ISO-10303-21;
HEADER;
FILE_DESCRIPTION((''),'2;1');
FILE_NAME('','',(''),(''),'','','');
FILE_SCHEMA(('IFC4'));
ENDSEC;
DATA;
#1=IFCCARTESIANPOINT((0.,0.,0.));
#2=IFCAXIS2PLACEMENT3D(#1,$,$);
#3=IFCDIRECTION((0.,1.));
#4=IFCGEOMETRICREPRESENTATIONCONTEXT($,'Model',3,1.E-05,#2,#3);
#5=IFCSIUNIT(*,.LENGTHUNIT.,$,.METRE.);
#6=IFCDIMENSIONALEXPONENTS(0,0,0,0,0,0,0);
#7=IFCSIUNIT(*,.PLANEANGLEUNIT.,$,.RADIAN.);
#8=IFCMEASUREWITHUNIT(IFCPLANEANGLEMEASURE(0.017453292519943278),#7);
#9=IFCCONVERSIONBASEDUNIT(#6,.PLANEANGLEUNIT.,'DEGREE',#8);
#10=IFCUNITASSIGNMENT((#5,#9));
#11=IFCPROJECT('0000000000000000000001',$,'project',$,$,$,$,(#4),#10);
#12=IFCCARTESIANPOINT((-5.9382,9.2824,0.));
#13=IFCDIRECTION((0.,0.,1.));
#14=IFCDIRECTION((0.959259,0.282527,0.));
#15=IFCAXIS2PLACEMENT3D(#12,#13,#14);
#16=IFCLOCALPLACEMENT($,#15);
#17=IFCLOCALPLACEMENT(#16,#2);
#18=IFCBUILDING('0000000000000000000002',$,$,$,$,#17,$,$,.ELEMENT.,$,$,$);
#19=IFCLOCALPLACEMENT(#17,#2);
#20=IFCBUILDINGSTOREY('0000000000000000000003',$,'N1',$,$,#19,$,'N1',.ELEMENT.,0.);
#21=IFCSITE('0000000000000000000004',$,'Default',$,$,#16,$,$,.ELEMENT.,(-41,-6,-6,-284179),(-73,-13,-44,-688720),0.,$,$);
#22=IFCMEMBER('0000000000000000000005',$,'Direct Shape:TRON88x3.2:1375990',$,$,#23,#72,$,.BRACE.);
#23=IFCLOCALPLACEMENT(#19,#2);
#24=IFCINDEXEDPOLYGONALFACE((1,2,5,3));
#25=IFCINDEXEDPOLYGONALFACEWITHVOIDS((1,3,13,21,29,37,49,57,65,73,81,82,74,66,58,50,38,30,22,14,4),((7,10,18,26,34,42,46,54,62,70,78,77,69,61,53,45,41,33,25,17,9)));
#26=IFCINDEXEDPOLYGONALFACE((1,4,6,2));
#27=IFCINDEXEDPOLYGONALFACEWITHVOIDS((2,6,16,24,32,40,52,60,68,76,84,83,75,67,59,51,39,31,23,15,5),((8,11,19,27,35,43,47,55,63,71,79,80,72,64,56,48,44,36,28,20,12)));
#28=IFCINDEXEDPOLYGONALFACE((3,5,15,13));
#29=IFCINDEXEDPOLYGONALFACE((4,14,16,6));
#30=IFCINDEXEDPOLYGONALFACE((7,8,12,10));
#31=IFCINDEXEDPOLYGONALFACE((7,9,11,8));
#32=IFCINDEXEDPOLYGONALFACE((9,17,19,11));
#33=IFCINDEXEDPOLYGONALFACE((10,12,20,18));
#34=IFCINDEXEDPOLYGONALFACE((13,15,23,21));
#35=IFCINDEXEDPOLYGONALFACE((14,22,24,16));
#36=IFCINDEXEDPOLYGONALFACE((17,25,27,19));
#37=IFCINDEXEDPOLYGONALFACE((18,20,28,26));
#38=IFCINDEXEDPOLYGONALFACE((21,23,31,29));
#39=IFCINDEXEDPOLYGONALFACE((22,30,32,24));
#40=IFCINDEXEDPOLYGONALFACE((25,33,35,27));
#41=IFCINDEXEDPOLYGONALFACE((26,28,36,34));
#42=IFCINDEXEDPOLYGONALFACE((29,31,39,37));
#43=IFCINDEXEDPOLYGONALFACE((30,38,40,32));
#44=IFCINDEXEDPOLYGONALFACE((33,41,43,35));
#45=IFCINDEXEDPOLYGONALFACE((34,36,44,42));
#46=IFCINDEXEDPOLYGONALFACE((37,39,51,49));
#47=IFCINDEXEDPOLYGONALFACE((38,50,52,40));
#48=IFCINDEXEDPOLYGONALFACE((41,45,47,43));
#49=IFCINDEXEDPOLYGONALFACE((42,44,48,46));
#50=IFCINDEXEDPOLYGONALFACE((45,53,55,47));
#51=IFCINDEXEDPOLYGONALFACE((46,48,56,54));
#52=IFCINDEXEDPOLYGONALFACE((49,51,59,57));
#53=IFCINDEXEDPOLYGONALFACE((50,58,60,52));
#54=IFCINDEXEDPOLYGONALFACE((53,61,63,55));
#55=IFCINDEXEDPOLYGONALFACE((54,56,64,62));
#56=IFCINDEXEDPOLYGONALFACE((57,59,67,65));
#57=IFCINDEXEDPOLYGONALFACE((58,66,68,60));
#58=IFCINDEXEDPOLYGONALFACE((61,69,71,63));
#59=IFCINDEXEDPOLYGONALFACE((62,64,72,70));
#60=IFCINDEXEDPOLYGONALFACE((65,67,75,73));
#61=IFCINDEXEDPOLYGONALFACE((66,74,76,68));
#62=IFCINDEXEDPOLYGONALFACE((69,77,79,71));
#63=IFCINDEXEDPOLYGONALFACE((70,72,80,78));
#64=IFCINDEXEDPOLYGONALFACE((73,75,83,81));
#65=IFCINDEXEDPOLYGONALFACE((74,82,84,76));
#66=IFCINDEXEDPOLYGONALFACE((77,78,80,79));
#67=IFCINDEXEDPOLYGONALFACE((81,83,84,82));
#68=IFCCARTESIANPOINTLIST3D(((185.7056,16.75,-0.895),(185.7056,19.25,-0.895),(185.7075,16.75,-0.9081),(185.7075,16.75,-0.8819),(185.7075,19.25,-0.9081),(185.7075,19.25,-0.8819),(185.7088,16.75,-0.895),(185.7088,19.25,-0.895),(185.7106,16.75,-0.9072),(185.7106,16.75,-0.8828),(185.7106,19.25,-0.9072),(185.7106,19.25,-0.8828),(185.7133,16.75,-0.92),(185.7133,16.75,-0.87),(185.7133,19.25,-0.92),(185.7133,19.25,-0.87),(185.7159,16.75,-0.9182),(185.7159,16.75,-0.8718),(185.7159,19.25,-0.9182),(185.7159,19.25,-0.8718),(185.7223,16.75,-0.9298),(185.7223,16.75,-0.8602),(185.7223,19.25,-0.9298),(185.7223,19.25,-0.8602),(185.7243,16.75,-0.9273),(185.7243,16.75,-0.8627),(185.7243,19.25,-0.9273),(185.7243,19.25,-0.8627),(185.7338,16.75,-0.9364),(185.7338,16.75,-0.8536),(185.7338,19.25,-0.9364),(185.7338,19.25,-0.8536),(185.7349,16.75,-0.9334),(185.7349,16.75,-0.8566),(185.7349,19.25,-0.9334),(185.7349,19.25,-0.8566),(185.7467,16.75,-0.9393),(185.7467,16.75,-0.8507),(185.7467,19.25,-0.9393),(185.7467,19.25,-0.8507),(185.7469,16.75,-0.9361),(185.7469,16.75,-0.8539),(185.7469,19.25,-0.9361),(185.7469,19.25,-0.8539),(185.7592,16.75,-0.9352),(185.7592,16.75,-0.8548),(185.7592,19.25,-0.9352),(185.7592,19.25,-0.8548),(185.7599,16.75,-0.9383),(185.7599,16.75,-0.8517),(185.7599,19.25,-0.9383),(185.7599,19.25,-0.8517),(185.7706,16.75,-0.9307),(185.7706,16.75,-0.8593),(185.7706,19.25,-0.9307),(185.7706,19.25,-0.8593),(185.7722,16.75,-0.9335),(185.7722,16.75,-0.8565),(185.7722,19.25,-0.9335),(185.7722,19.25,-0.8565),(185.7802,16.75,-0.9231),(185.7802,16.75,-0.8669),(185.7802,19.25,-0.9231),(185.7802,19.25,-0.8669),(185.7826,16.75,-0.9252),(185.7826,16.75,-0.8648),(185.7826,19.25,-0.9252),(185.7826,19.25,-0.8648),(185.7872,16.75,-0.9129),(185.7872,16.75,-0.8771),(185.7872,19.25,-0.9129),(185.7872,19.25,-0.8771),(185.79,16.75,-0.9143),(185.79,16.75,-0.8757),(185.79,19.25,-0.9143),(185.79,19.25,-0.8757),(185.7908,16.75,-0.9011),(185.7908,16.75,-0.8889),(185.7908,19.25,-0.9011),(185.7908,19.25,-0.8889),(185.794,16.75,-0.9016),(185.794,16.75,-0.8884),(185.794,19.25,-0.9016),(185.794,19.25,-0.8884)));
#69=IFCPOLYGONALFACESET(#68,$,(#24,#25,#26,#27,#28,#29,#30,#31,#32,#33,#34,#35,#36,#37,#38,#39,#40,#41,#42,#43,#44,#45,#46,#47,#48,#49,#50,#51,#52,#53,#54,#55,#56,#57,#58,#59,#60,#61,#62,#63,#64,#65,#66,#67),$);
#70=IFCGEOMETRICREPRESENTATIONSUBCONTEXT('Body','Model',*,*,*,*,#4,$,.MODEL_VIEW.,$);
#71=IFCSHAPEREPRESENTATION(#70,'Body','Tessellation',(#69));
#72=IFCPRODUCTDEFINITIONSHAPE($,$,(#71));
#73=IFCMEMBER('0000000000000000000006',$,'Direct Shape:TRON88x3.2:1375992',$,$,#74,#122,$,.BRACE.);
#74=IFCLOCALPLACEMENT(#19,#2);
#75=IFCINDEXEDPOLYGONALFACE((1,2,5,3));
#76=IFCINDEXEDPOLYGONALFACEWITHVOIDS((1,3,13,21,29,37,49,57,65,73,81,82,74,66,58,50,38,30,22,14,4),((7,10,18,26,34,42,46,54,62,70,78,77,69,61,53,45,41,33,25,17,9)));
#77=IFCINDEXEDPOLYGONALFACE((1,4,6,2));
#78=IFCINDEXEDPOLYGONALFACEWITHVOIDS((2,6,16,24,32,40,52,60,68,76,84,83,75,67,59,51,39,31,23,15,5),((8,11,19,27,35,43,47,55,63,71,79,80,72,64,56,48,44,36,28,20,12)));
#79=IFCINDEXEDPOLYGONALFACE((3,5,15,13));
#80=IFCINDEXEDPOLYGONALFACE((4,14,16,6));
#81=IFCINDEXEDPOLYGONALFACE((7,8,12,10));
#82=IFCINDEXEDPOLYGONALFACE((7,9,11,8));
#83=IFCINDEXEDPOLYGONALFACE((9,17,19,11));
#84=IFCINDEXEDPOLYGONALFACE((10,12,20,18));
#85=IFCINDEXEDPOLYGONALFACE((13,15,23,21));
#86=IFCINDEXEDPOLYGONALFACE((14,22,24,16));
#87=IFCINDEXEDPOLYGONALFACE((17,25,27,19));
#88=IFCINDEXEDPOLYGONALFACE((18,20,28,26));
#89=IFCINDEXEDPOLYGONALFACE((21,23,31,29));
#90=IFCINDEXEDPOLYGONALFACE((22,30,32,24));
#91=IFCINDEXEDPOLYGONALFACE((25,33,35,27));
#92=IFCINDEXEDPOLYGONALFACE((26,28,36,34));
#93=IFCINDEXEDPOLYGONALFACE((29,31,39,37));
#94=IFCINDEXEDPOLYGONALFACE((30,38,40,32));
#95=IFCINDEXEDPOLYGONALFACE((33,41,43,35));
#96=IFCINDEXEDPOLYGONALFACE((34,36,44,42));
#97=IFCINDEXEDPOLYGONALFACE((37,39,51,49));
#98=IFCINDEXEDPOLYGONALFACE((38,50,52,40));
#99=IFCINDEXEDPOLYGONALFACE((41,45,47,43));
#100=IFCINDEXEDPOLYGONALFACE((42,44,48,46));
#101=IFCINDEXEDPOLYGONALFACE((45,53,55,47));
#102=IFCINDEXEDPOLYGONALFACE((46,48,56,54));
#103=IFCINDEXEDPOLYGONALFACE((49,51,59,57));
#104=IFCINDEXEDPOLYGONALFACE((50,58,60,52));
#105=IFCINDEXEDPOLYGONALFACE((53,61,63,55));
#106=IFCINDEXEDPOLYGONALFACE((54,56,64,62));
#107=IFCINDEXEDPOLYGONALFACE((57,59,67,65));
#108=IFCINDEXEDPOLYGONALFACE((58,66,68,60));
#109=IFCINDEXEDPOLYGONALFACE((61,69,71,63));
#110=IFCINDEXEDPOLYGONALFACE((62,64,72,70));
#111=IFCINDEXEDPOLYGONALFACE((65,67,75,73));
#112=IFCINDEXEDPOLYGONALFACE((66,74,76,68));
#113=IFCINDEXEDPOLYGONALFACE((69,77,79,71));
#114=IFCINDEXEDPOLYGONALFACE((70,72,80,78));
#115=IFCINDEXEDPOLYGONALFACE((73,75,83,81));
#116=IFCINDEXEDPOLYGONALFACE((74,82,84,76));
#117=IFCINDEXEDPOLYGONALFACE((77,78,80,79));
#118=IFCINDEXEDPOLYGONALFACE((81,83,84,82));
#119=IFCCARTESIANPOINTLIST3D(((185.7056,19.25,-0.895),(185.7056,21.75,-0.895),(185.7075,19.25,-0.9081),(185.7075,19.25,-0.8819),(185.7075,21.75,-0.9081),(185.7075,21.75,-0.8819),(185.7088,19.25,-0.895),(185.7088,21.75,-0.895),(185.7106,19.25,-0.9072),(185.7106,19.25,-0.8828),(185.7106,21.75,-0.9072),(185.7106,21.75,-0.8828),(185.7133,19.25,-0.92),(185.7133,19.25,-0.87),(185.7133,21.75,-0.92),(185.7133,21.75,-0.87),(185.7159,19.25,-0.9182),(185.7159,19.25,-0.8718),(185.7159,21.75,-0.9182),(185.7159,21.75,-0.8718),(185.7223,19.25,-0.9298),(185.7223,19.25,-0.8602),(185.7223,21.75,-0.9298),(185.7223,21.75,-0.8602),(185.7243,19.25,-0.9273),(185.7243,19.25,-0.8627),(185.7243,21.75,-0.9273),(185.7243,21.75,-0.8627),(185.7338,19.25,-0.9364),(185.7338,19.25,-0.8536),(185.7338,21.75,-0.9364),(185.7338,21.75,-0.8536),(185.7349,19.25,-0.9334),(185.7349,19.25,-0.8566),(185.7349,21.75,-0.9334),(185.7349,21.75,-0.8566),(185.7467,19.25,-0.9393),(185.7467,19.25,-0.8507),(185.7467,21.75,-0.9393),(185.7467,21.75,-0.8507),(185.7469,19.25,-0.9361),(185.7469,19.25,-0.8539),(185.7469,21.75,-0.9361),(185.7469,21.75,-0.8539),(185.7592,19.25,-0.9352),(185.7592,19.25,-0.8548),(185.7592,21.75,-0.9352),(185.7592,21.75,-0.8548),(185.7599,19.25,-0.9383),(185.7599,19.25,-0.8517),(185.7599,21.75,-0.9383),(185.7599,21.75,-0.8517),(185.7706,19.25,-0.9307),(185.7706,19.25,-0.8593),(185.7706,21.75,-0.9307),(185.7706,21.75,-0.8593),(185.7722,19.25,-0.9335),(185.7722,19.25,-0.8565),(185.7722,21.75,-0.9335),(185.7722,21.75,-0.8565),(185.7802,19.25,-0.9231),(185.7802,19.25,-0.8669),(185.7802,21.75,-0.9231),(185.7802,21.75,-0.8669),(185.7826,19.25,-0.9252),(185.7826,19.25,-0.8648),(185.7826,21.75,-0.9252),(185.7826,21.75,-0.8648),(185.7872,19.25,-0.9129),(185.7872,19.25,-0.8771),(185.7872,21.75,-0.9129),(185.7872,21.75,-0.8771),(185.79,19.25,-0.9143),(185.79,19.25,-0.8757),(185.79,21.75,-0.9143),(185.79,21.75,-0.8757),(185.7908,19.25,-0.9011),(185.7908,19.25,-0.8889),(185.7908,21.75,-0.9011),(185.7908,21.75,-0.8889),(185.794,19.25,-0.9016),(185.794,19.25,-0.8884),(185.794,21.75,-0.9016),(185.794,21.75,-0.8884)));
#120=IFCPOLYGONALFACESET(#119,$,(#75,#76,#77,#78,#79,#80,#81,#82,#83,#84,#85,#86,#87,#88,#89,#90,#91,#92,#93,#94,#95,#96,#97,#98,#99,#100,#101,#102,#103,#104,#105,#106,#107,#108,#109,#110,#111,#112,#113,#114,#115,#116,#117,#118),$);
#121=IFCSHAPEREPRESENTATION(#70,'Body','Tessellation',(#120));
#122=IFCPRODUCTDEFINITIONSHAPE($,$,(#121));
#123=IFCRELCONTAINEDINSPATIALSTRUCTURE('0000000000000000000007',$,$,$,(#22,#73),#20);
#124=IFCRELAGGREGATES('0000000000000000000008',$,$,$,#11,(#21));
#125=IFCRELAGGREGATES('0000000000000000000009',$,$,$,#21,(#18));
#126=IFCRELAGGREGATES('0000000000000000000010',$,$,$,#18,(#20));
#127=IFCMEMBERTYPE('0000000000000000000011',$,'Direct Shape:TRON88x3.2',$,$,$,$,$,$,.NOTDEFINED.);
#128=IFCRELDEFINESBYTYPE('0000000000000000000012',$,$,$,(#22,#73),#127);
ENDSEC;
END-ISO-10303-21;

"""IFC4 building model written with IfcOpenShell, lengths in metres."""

from ifc_helpers import new_model, entity, si_unit, converted_unit, direction, frame, frame_2d, origin, place, context, subcontext, project, spatial, hollow_circle, extrude, type_object, element, save


model = new_model("IFC4")

# Units and contexts
model_context = context("Model", 3, precision=1e-05, world=origin(), true_north=direction((0.0, 1.0)))
body_context = subcontext(model_context, "Body", "Model", "MODEL_VIEW")
ifc_project = project(units=[si_unit("LENGTHUNIT", "METRE"), converted_unit("PLANEANGLEUNIT", "DEGREE", entity("IfcPlaneAngleMeasure", 0.017453292519943278), si_unit("PLANEANGLEUNIT", "RADIAN"), dimensions=[0, 0, 0, 0, 0, 0, 0])], contexts=[model_context])

# Site, building, storey
site_placement = place(None, frame((-5.9382, 9.2824, 0.0), z_axis=(0.0, 0.0, 1.0), x_axis=(0.959259, 0.282527, 0.0)))
site = spatial("IfcSite", under=ifc_project, at=site_placement, Name="Default", CompositionType="ELEMENT", RefLatitude=(-41, -6, -6, -284179), RefLongitude=(-73, -13, -44, -688720), RefElevation=0.0)
building_placement = place(site_placement, origin())
building = spatial("IfcBuilding", under=site, at=building_placement, CompositionType="ELEMENT")
storey_placement = place(building_placement, origin())
storey = spatial("IfcBuildingStorey", under=building, at=storey_placement, Name="N1", LongName="N1", CompositionType="ELEMENT", Elevation=0.0)

# Members
member_type_1 = type_object("IfcMemberType", Name="Direct Shape:TRON88x3.2", PredefinedType="NOTDEFINED")
member_1_placement = place(storey_placement, origin())
element("IfcMember", 1, at=member_1_placement, inside=storey, type_object=member_type_1, Name="Direct Shape:TRON88x3.2:1375990", PredefinedType="BRACE", context=body_context, shape_type="SweptSolid", body=[
    extrude(hollow_circle(Radius=0.0445, WallThickness=0.0032, at=frame_2d((0.0, 0.0), x_axis=(1.0, 0.0))), frame((185.75, 16.75, -0.895), z_axis=(0.0, 1.0, 0.0), x_axis=(-1.0, 0.0, 0.0)), (0.0, 0.0, 1.0), 2.5),
])
member_2_placement = place(storey_placement, origin())
element("IfcMember", 2, at=member_2_placement, inside=storey, type_object=member_type_1, Name="Direct Shape:TRON88x3.2:1375992", PredefinedType="BRACE", context=body_context, shape_type="SweptSolid", body=[
    extrude(hollow_circle(Radius=0.0445, WallThickness=0.0032, at=frame_2d((0.0, 0.0), x_axis=(1.0, 0.0))), frame((185.75, 19.25, -0.895), z_axis=(0.0, 1.0, 0.0), x_axis=(-1.0, 0.0, 0.0)), (0.0, 0.0, 1.0), 2.5),
])

save(model, "model.ifc")
